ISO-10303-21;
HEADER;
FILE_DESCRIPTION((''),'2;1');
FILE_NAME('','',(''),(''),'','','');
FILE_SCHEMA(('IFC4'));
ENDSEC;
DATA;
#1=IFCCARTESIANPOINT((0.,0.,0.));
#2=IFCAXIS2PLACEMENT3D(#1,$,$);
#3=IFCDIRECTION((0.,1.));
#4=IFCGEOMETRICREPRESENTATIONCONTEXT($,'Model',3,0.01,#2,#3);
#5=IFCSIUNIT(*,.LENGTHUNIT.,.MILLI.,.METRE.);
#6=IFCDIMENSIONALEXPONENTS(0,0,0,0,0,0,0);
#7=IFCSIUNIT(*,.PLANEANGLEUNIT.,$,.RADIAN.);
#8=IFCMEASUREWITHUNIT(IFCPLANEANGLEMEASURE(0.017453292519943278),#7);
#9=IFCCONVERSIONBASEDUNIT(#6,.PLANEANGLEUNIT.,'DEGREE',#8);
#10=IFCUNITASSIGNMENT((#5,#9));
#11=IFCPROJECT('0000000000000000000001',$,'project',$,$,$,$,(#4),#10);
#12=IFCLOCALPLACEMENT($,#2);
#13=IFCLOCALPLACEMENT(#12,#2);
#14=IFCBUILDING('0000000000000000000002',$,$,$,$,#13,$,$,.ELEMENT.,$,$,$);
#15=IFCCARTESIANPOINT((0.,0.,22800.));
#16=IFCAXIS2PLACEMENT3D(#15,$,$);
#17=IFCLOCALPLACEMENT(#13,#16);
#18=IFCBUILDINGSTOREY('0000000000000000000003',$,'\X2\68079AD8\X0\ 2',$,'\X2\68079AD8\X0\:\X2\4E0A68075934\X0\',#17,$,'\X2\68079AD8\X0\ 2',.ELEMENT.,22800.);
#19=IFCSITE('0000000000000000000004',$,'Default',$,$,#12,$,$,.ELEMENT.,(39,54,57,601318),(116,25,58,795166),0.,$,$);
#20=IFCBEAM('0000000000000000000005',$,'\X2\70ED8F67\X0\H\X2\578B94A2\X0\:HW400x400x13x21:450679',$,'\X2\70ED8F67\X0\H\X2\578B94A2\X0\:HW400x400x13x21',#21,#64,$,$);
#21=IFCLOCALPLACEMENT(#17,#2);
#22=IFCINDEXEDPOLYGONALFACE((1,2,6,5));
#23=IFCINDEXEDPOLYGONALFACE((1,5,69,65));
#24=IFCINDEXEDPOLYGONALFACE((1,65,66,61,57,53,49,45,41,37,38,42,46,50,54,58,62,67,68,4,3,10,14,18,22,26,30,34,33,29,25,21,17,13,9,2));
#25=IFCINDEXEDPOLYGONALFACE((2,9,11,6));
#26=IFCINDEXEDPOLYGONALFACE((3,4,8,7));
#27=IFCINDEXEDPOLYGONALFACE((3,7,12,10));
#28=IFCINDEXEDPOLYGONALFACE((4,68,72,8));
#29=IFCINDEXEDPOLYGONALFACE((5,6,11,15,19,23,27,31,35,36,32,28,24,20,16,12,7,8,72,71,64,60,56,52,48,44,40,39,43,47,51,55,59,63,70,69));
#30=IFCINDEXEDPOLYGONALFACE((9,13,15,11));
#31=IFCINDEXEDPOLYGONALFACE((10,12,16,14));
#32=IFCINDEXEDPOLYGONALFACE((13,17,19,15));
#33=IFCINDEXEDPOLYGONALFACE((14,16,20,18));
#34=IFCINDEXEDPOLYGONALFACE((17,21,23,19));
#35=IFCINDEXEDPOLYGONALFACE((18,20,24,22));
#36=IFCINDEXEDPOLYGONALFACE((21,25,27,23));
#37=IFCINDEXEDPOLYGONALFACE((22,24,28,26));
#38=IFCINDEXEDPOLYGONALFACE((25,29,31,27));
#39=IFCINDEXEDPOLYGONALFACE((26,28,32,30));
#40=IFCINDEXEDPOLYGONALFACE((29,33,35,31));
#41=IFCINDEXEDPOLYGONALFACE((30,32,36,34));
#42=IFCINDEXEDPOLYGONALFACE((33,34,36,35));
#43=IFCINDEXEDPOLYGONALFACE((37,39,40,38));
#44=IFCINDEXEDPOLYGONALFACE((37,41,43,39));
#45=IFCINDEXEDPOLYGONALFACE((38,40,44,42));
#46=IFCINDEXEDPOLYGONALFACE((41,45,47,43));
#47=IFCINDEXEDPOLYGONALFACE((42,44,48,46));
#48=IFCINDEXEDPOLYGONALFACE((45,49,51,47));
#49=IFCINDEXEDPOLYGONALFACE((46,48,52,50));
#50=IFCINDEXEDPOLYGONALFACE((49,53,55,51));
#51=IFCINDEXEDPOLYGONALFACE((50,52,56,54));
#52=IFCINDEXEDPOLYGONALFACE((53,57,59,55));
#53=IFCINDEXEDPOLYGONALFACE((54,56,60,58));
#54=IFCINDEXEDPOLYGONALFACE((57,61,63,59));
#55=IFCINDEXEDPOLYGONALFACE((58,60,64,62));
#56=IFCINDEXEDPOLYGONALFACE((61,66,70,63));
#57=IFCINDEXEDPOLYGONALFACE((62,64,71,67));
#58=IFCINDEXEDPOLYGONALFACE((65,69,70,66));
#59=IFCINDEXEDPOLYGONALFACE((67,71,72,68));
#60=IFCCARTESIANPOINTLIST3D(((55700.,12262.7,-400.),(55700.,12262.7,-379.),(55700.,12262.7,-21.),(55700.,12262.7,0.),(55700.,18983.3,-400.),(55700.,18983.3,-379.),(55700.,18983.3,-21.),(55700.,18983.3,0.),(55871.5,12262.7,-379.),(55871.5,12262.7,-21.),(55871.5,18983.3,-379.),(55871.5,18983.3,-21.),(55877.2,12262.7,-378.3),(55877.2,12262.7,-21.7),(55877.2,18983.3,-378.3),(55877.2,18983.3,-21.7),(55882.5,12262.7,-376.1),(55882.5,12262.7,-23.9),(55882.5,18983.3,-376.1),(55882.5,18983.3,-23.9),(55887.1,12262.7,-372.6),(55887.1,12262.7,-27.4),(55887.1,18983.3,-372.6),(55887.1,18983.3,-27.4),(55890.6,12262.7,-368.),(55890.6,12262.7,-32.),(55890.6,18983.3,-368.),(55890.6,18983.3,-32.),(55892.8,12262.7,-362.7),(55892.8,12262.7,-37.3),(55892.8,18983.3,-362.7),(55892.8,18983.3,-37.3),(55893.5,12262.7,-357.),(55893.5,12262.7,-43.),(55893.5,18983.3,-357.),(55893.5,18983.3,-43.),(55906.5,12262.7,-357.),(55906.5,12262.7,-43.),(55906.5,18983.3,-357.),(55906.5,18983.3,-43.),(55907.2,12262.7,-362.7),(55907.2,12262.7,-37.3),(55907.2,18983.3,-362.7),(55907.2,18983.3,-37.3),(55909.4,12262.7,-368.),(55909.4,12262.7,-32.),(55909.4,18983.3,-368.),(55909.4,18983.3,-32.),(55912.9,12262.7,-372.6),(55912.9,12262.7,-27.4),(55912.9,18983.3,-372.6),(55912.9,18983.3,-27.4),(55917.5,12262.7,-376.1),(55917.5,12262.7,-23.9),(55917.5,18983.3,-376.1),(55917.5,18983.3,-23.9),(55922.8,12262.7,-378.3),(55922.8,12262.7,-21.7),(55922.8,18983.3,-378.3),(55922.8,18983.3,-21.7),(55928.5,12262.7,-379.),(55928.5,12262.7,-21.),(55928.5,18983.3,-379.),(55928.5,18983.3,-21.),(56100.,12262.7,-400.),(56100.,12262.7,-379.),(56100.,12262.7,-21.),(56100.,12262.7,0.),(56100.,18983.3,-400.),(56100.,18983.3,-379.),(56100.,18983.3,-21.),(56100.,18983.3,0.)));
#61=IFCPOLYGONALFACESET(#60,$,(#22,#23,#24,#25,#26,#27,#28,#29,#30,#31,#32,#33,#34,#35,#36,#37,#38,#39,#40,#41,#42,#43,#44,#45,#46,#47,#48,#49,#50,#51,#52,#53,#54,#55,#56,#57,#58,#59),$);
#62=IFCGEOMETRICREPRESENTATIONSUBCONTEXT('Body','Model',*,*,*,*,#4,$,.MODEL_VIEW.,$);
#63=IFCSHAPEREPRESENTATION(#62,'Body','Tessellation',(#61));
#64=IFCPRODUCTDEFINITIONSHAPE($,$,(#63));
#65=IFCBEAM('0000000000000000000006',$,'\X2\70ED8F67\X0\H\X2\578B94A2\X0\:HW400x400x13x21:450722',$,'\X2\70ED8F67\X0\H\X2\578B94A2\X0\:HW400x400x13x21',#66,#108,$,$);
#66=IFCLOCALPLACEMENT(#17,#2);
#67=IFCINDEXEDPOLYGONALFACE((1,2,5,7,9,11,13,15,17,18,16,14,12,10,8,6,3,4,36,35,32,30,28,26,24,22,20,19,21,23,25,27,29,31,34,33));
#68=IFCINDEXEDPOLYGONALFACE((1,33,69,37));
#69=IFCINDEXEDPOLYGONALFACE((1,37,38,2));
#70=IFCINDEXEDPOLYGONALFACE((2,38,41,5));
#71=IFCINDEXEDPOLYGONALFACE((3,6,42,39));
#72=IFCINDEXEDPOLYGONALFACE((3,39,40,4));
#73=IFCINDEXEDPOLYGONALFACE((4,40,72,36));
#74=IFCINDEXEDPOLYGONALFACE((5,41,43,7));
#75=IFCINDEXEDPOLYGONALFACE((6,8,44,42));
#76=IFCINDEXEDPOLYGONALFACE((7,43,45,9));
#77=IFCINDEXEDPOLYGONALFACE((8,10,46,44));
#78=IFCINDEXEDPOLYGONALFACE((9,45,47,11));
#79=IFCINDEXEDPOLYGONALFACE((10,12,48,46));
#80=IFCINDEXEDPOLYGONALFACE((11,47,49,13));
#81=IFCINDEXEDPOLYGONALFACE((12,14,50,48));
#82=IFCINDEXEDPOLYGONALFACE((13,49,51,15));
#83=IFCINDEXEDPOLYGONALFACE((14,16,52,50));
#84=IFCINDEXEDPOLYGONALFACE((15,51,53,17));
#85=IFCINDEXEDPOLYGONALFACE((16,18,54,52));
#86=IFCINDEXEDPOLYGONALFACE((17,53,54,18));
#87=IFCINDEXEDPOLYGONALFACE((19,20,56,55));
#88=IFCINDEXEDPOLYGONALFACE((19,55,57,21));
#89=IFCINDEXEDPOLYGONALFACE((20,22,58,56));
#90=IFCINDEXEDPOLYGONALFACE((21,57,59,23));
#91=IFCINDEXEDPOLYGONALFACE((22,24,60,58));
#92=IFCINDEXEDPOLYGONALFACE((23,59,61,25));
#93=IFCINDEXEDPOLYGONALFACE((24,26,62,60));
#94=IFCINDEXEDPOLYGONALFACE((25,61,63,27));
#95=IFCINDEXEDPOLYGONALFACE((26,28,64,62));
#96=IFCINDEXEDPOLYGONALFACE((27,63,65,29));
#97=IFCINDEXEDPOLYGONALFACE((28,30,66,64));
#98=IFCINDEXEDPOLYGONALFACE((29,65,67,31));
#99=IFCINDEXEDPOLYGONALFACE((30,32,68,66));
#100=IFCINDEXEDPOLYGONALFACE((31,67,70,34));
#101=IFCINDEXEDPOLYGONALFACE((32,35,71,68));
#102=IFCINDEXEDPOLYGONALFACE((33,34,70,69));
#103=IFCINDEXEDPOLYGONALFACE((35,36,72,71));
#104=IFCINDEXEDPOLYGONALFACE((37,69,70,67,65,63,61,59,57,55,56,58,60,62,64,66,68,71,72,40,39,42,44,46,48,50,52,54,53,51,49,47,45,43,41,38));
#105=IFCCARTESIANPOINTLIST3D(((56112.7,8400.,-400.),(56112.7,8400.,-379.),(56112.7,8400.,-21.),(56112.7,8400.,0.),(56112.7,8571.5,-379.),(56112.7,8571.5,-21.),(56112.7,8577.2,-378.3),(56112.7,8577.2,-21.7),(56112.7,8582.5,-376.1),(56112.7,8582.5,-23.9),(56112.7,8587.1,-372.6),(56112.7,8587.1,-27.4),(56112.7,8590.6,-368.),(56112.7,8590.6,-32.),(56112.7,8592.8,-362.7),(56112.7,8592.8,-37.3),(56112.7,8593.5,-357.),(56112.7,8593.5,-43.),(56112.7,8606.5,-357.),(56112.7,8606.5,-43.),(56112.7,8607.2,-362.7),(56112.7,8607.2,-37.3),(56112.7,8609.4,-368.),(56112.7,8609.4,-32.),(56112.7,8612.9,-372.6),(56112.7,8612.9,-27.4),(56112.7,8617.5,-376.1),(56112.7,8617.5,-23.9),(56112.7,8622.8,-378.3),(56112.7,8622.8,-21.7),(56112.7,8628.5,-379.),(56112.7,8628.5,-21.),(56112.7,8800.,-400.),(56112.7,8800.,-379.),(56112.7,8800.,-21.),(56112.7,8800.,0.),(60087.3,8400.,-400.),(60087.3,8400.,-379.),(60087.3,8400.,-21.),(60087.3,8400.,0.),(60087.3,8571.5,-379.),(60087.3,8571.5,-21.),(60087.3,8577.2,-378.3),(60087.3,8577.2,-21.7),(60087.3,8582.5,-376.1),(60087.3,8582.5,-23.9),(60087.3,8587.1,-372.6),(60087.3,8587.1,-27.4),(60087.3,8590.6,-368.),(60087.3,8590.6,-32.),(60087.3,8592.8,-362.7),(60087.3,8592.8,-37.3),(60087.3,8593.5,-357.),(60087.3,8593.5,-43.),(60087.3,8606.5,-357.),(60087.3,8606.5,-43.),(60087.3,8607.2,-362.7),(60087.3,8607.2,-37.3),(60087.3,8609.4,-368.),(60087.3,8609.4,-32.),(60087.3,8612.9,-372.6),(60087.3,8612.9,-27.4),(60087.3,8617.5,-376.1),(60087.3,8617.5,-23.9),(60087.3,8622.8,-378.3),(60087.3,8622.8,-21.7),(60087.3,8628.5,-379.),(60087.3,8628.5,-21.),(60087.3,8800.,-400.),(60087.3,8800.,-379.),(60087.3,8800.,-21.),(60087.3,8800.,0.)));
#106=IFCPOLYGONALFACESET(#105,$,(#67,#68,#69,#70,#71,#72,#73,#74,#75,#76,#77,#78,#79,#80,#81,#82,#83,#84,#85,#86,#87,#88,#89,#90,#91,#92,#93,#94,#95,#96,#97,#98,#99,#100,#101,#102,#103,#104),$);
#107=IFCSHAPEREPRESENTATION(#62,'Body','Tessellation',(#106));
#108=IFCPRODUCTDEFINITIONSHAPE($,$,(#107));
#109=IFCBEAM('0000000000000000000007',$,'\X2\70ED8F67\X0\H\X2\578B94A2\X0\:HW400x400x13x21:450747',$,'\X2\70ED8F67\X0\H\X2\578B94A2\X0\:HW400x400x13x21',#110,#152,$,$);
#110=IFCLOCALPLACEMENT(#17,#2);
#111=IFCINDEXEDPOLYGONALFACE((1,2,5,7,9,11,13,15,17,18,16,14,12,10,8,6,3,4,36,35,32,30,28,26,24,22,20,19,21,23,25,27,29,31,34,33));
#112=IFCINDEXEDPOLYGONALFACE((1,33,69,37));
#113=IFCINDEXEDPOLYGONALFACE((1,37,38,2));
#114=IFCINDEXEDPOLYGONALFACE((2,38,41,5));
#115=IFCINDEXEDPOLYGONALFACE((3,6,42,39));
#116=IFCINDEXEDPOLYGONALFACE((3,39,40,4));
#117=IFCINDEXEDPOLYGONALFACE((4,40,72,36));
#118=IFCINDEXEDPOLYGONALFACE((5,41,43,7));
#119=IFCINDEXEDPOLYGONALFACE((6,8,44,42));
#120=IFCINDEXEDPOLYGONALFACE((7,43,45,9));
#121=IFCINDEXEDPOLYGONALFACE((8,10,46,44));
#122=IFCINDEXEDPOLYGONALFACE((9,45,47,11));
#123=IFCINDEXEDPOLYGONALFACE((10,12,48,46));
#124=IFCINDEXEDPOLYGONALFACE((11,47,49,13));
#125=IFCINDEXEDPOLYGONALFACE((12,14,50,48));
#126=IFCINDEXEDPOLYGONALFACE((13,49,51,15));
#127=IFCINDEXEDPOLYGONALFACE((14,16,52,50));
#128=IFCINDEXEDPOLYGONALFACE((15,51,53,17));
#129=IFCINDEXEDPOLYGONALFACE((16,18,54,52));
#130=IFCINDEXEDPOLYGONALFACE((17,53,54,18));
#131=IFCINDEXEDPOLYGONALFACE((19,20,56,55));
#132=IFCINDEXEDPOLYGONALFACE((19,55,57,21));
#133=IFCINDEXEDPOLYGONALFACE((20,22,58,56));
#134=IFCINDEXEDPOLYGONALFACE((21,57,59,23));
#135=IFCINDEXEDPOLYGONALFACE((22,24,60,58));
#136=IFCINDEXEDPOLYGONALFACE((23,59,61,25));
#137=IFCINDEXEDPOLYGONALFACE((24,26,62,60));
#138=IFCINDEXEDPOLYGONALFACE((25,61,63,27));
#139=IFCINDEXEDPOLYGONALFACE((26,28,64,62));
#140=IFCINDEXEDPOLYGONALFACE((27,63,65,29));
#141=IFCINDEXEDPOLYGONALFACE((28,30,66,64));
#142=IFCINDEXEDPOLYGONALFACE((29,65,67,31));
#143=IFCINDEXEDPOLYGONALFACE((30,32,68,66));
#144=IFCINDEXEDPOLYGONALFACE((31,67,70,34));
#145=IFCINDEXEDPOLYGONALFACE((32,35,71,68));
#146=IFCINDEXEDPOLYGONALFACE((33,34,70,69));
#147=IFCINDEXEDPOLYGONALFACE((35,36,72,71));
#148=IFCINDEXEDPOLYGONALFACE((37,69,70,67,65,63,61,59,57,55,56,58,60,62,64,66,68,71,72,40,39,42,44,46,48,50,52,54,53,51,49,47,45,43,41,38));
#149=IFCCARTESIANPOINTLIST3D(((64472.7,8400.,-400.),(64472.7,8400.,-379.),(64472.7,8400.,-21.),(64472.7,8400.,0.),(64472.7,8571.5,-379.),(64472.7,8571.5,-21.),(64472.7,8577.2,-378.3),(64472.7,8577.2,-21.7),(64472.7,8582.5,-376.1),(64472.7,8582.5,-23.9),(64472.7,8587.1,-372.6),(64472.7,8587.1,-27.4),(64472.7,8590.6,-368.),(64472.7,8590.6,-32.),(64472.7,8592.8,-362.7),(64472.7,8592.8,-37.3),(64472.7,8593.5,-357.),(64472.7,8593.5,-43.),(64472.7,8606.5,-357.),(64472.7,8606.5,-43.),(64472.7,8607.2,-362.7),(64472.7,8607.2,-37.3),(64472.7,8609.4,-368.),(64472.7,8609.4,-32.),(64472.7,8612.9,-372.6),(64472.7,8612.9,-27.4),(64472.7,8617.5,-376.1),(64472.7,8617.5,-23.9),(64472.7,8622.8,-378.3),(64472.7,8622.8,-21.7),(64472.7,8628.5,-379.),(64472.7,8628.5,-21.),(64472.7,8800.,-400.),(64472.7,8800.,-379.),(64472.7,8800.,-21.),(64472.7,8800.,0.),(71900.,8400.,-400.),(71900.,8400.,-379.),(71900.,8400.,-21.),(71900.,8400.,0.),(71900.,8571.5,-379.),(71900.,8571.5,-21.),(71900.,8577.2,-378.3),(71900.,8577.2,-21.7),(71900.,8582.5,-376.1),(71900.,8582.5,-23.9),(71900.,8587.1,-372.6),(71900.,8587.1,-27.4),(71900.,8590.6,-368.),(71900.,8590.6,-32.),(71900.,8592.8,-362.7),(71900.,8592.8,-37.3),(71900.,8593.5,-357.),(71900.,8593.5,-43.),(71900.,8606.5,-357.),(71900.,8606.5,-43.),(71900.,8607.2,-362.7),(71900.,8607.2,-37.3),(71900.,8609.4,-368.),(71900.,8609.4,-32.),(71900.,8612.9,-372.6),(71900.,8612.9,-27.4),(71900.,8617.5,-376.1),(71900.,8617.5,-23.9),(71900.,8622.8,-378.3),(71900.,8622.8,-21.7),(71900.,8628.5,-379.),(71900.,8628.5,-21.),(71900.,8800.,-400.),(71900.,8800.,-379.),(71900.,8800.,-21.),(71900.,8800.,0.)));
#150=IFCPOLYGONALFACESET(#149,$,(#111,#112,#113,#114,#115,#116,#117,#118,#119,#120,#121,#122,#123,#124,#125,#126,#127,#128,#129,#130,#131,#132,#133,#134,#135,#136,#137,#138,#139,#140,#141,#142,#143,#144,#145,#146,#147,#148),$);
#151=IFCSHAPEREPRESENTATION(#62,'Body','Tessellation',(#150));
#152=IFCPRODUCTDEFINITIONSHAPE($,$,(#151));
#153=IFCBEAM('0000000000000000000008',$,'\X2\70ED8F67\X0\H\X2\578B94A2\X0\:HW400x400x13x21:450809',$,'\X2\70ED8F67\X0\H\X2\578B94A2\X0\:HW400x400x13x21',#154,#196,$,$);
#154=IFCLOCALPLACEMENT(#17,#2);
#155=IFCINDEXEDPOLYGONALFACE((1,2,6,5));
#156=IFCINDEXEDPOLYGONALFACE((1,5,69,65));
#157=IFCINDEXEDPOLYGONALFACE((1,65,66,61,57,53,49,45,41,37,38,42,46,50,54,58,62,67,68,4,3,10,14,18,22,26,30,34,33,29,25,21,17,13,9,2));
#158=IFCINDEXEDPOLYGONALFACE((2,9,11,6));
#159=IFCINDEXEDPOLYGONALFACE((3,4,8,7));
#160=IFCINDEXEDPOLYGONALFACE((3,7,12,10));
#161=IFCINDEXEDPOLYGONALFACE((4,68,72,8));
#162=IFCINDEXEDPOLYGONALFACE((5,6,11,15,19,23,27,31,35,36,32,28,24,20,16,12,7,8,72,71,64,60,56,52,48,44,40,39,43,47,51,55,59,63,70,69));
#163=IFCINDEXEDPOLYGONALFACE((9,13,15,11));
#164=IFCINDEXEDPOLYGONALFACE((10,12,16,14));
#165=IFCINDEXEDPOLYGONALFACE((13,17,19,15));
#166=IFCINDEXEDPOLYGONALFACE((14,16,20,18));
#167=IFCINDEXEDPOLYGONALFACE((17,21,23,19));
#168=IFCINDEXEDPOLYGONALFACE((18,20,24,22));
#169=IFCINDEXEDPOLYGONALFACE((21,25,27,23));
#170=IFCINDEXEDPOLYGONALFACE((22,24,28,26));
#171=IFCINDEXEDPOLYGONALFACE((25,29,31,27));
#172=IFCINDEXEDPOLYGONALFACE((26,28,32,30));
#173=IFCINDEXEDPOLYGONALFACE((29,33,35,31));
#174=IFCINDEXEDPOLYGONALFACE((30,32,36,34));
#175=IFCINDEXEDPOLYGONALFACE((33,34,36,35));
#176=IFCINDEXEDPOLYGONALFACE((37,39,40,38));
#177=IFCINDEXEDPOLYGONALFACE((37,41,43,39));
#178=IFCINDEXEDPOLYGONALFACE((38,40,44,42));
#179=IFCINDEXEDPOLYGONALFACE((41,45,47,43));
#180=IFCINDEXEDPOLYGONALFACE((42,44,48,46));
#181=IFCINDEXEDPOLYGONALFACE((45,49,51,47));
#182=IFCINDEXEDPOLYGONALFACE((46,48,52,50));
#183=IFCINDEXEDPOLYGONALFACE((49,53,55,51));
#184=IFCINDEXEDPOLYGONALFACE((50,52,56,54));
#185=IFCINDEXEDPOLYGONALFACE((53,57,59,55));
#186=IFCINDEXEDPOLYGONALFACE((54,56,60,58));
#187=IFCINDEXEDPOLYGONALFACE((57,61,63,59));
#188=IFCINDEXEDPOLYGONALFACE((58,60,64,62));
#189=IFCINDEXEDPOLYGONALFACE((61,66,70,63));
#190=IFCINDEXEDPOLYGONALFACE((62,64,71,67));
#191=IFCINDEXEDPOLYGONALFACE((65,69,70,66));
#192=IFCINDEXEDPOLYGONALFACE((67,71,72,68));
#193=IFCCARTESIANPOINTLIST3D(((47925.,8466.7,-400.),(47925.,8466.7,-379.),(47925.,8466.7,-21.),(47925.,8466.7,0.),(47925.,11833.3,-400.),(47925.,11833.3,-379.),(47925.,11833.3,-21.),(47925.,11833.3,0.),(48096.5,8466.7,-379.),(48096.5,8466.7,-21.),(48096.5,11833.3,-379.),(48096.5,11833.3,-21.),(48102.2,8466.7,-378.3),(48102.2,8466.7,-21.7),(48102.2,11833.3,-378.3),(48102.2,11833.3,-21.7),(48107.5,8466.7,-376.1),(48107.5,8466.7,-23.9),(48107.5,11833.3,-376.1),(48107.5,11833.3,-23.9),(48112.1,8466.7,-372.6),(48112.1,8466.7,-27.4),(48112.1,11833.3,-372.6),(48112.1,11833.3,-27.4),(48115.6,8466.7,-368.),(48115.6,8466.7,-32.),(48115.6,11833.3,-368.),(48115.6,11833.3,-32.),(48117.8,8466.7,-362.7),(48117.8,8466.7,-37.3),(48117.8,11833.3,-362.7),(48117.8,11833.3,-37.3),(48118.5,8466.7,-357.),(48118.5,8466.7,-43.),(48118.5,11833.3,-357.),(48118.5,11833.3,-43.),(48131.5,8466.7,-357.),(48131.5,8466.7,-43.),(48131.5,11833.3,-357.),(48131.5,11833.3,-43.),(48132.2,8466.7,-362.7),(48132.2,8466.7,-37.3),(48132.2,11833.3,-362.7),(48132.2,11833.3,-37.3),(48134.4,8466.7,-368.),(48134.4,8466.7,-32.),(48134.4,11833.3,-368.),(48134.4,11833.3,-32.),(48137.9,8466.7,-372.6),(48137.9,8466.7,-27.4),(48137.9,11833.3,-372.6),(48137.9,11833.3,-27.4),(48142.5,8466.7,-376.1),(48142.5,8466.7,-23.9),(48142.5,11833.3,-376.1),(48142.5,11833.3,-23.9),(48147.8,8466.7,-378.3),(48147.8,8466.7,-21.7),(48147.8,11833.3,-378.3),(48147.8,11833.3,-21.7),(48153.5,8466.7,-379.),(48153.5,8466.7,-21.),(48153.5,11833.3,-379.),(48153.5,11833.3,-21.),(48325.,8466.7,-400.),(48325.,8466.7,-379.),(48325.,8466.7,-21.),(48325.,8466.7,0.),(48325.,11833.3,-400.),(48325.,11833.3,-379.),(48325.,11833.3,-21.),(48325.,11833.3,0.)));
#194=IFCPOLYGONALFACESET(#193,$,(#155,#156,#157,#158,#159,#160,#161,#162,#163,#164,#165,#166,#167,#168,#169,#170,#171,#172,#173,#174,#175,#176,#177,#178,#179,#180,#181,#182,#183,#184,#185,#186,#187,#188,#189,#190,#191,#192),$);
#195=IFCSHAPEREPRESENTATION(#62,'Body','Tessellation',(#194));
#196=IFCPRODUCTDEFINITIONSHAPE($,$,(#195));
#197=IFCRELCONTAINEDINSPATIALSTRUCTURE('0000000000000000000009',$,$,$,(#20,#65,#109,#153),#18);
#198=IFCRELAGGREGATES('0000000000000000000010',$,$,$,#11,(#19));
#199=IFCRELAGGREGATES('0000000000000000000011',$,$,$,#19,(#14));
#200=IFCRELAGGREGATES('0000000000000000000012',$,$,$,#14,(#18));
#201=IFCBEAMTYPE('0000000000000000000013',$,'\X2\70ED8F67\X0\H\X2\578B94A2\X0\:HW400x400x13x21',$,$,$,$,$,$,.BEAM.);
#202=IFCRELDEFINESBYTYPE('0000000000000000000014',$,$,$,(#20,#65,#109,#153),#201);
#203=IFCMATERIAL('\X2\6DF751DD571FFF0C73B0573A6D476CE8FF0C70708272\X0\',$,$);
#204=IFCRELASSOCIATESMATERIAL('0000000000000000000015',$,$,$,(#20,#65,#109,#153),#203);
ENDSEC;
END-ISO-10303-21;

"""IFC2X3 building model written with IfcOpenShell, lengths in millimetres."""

from ifc_helpers import new_model, entity, si_unit, converted_unit, direction, frame, frame_2d, origin, place, context, subcontext, project, spatial, i_section, extrude, material, type_object, element, save


model = new_model("IFC2X3")

# Units and contexts
model_context = context("Model", 3, precision=0.01, world=origin(), true_north=direction((0.0, 1.0)))
body_context = subcontext(model_context, "Body", "Model", "MODEL_VIEW")
ifc_project = project(units=[si_unit("LENGTHUNIT", "METRE", prefix="MILLI"), converted_unit("PLANEANGLEUNIT", "DEGREE", entity("IfcPlaneAngleMeasure", 0.017453292519943278), si_unit("PLANEANGLEUNIT", "RADIAN"), dimensions=[0, 0, 0, 0, 0, 0, 0])], contexts=[model_context])

# Site, building, storey
site_placement = place(None, origin())
site = spatial("IfcSite", under=ifc_project, at=site_placement, Name="Default", CompositionType="ELEMENT", RefLatitude=(39, 54, 57, 601318), RefLongitude=(116, 25, 58, 795166), RefElevation=0.0)
building_placement = place(site_placement, origin())
building = spatial("IfcBuilding", under=site, at=building_placement, CompositionType="ELEMENT")
storey_placement = place(building_placement, frame((0.0, 0.0, 22800.0)))
storey = spatial("IfcBuildingStorey", under=building, at=storey_placement, Name="标高 2", ObjectType="标高:上标头", LongName="标高 2", CompositionType="ELEMENT", Elevation=22800.0)

# Beams
ifc_material = material(Name="混凝土，现场浇注，灰色")
beam_type = type_object("IfcBeamType", Name="热轧H型钢:HW400x400x13x21", PredefinedType="BEAM")
beam_1_placement = place(storey_placement, frame((55900.0, 19250.0, 0.0), z_axis=(0.0, 0.0, 1.0), x_axis=(0.0, -1.0, 0.0)))
element("IfcBeam", 1, at=beam_1_placement, inside=storey, type_object=beam_type, material=ifc_material, Name="热轧H型钢:HW400x400x13x21:450679", ObjectType="热轧H型钢:HW400x400x13x21", context=body_context, shape_type="SweptSolid", body=[
    extrude(i_section(OverallWidth=400.0, OverallDepth=400.0, WebThickness=13.0, FlangeThickness=21.0, FilletRadius=22.0, at=frame_2d((0.0, 0.0), x_axis=(0.0, 1.0))), frame((266.7, 0.0, -200.0), z_axis=(1.0, 0.0, 0.0), x_axis=(0.0, 0.0, -1.0)), (0.0, 0.0, 1.0), 6720.6),
])
beam_2_placement = place(storey_placement, frame((55900.0, 8600.0, 0.0)))
element("IfcBeam", 2, at=beam_2_placement, inside=storey, type_object=beam_type, material=ifc_material, Name="热轧H型钢:HW400x400x13x21:450722", ObjectType="热轧H型钢:HW400x400x13x21", context=body_context, shape_type="SweptSolid", body=[
    extrude(i_section(OverallWidth=400.0, OverallDepth=400.0, WebThickness=13.0, FlangeThickness=21.0, FilletRadius=22.0, at=frame_2d((0.0, 0.0), x_axis=(0.0, 1.0))), frame((212.7, 0.0, -200.0), z_axis=(1.0, 0.0, 0.0), x_axis=(0.0, 0.0, -1.0)), (0.0, 0.0, 1.0), 3974.6),
])
beam_3_placement = place(storey_placement, frame((64260.0, 8600.0, 0.0)))
element("IfcBeam", 3, at=beam_3_placement, inside=storey, type_object=beam_type, material=ifc_material, Name="热轧H型钢:HW400x400x13x21:450747", ObjectType="热轧H型钢:HW400x400x13x21", context=body_context, shape_type="SweptSolid", body=[
    extrude(i_section(OverallWidth=400.0, OverallDepth=400.0, WebThickness=13.0, FlangeThickness=21.0, FilletRadius=22.0, at=frame_2d((0.0, 0.0), x_axis=(0.0, 1.0))), frame((212.7, 0.0, -200.0), z_axis=(1.0, 0.0, 0.0), x_axis=(0.0, 0.0, -1.0)), (0.0, 0.0, 1.0), 7427.3),
])
beam_4_placement = place(storey_placement, frame((48125.0, 11840.0, 0.0), z_axis=(0.0, 0.0, 1.0), x_axis=(0.0, -1.0, 0.0)))
element("IfcBeam", 4, at=beam_4_placement, inside=storey, type_object=beam_type, material=ifc_material, Name="热轧H型钢:HW400x400x13x21:450809", ObjectType="热轧H型钢:HW400x400x13x21", context=body_context, shape_type="SweptSolid", body=[
    extrude(i_section(OverallWidth=400.0, OverallDepth=400.0, WebThickness=13.0, FlangeThickness=21.0, FilletRadius=22.0, at=frame_2d((0.0, 0.0), x_axis=(0.0, 1.0))), frame((6.7, 0.0, -200.0), z_axis=(1.0, 0.0, 0.0), x_axis=(0.0, 0.0, -1.0)), (0.0, 0.0, 1.0), 3366.6),
])

save(model, "model.ifc")
